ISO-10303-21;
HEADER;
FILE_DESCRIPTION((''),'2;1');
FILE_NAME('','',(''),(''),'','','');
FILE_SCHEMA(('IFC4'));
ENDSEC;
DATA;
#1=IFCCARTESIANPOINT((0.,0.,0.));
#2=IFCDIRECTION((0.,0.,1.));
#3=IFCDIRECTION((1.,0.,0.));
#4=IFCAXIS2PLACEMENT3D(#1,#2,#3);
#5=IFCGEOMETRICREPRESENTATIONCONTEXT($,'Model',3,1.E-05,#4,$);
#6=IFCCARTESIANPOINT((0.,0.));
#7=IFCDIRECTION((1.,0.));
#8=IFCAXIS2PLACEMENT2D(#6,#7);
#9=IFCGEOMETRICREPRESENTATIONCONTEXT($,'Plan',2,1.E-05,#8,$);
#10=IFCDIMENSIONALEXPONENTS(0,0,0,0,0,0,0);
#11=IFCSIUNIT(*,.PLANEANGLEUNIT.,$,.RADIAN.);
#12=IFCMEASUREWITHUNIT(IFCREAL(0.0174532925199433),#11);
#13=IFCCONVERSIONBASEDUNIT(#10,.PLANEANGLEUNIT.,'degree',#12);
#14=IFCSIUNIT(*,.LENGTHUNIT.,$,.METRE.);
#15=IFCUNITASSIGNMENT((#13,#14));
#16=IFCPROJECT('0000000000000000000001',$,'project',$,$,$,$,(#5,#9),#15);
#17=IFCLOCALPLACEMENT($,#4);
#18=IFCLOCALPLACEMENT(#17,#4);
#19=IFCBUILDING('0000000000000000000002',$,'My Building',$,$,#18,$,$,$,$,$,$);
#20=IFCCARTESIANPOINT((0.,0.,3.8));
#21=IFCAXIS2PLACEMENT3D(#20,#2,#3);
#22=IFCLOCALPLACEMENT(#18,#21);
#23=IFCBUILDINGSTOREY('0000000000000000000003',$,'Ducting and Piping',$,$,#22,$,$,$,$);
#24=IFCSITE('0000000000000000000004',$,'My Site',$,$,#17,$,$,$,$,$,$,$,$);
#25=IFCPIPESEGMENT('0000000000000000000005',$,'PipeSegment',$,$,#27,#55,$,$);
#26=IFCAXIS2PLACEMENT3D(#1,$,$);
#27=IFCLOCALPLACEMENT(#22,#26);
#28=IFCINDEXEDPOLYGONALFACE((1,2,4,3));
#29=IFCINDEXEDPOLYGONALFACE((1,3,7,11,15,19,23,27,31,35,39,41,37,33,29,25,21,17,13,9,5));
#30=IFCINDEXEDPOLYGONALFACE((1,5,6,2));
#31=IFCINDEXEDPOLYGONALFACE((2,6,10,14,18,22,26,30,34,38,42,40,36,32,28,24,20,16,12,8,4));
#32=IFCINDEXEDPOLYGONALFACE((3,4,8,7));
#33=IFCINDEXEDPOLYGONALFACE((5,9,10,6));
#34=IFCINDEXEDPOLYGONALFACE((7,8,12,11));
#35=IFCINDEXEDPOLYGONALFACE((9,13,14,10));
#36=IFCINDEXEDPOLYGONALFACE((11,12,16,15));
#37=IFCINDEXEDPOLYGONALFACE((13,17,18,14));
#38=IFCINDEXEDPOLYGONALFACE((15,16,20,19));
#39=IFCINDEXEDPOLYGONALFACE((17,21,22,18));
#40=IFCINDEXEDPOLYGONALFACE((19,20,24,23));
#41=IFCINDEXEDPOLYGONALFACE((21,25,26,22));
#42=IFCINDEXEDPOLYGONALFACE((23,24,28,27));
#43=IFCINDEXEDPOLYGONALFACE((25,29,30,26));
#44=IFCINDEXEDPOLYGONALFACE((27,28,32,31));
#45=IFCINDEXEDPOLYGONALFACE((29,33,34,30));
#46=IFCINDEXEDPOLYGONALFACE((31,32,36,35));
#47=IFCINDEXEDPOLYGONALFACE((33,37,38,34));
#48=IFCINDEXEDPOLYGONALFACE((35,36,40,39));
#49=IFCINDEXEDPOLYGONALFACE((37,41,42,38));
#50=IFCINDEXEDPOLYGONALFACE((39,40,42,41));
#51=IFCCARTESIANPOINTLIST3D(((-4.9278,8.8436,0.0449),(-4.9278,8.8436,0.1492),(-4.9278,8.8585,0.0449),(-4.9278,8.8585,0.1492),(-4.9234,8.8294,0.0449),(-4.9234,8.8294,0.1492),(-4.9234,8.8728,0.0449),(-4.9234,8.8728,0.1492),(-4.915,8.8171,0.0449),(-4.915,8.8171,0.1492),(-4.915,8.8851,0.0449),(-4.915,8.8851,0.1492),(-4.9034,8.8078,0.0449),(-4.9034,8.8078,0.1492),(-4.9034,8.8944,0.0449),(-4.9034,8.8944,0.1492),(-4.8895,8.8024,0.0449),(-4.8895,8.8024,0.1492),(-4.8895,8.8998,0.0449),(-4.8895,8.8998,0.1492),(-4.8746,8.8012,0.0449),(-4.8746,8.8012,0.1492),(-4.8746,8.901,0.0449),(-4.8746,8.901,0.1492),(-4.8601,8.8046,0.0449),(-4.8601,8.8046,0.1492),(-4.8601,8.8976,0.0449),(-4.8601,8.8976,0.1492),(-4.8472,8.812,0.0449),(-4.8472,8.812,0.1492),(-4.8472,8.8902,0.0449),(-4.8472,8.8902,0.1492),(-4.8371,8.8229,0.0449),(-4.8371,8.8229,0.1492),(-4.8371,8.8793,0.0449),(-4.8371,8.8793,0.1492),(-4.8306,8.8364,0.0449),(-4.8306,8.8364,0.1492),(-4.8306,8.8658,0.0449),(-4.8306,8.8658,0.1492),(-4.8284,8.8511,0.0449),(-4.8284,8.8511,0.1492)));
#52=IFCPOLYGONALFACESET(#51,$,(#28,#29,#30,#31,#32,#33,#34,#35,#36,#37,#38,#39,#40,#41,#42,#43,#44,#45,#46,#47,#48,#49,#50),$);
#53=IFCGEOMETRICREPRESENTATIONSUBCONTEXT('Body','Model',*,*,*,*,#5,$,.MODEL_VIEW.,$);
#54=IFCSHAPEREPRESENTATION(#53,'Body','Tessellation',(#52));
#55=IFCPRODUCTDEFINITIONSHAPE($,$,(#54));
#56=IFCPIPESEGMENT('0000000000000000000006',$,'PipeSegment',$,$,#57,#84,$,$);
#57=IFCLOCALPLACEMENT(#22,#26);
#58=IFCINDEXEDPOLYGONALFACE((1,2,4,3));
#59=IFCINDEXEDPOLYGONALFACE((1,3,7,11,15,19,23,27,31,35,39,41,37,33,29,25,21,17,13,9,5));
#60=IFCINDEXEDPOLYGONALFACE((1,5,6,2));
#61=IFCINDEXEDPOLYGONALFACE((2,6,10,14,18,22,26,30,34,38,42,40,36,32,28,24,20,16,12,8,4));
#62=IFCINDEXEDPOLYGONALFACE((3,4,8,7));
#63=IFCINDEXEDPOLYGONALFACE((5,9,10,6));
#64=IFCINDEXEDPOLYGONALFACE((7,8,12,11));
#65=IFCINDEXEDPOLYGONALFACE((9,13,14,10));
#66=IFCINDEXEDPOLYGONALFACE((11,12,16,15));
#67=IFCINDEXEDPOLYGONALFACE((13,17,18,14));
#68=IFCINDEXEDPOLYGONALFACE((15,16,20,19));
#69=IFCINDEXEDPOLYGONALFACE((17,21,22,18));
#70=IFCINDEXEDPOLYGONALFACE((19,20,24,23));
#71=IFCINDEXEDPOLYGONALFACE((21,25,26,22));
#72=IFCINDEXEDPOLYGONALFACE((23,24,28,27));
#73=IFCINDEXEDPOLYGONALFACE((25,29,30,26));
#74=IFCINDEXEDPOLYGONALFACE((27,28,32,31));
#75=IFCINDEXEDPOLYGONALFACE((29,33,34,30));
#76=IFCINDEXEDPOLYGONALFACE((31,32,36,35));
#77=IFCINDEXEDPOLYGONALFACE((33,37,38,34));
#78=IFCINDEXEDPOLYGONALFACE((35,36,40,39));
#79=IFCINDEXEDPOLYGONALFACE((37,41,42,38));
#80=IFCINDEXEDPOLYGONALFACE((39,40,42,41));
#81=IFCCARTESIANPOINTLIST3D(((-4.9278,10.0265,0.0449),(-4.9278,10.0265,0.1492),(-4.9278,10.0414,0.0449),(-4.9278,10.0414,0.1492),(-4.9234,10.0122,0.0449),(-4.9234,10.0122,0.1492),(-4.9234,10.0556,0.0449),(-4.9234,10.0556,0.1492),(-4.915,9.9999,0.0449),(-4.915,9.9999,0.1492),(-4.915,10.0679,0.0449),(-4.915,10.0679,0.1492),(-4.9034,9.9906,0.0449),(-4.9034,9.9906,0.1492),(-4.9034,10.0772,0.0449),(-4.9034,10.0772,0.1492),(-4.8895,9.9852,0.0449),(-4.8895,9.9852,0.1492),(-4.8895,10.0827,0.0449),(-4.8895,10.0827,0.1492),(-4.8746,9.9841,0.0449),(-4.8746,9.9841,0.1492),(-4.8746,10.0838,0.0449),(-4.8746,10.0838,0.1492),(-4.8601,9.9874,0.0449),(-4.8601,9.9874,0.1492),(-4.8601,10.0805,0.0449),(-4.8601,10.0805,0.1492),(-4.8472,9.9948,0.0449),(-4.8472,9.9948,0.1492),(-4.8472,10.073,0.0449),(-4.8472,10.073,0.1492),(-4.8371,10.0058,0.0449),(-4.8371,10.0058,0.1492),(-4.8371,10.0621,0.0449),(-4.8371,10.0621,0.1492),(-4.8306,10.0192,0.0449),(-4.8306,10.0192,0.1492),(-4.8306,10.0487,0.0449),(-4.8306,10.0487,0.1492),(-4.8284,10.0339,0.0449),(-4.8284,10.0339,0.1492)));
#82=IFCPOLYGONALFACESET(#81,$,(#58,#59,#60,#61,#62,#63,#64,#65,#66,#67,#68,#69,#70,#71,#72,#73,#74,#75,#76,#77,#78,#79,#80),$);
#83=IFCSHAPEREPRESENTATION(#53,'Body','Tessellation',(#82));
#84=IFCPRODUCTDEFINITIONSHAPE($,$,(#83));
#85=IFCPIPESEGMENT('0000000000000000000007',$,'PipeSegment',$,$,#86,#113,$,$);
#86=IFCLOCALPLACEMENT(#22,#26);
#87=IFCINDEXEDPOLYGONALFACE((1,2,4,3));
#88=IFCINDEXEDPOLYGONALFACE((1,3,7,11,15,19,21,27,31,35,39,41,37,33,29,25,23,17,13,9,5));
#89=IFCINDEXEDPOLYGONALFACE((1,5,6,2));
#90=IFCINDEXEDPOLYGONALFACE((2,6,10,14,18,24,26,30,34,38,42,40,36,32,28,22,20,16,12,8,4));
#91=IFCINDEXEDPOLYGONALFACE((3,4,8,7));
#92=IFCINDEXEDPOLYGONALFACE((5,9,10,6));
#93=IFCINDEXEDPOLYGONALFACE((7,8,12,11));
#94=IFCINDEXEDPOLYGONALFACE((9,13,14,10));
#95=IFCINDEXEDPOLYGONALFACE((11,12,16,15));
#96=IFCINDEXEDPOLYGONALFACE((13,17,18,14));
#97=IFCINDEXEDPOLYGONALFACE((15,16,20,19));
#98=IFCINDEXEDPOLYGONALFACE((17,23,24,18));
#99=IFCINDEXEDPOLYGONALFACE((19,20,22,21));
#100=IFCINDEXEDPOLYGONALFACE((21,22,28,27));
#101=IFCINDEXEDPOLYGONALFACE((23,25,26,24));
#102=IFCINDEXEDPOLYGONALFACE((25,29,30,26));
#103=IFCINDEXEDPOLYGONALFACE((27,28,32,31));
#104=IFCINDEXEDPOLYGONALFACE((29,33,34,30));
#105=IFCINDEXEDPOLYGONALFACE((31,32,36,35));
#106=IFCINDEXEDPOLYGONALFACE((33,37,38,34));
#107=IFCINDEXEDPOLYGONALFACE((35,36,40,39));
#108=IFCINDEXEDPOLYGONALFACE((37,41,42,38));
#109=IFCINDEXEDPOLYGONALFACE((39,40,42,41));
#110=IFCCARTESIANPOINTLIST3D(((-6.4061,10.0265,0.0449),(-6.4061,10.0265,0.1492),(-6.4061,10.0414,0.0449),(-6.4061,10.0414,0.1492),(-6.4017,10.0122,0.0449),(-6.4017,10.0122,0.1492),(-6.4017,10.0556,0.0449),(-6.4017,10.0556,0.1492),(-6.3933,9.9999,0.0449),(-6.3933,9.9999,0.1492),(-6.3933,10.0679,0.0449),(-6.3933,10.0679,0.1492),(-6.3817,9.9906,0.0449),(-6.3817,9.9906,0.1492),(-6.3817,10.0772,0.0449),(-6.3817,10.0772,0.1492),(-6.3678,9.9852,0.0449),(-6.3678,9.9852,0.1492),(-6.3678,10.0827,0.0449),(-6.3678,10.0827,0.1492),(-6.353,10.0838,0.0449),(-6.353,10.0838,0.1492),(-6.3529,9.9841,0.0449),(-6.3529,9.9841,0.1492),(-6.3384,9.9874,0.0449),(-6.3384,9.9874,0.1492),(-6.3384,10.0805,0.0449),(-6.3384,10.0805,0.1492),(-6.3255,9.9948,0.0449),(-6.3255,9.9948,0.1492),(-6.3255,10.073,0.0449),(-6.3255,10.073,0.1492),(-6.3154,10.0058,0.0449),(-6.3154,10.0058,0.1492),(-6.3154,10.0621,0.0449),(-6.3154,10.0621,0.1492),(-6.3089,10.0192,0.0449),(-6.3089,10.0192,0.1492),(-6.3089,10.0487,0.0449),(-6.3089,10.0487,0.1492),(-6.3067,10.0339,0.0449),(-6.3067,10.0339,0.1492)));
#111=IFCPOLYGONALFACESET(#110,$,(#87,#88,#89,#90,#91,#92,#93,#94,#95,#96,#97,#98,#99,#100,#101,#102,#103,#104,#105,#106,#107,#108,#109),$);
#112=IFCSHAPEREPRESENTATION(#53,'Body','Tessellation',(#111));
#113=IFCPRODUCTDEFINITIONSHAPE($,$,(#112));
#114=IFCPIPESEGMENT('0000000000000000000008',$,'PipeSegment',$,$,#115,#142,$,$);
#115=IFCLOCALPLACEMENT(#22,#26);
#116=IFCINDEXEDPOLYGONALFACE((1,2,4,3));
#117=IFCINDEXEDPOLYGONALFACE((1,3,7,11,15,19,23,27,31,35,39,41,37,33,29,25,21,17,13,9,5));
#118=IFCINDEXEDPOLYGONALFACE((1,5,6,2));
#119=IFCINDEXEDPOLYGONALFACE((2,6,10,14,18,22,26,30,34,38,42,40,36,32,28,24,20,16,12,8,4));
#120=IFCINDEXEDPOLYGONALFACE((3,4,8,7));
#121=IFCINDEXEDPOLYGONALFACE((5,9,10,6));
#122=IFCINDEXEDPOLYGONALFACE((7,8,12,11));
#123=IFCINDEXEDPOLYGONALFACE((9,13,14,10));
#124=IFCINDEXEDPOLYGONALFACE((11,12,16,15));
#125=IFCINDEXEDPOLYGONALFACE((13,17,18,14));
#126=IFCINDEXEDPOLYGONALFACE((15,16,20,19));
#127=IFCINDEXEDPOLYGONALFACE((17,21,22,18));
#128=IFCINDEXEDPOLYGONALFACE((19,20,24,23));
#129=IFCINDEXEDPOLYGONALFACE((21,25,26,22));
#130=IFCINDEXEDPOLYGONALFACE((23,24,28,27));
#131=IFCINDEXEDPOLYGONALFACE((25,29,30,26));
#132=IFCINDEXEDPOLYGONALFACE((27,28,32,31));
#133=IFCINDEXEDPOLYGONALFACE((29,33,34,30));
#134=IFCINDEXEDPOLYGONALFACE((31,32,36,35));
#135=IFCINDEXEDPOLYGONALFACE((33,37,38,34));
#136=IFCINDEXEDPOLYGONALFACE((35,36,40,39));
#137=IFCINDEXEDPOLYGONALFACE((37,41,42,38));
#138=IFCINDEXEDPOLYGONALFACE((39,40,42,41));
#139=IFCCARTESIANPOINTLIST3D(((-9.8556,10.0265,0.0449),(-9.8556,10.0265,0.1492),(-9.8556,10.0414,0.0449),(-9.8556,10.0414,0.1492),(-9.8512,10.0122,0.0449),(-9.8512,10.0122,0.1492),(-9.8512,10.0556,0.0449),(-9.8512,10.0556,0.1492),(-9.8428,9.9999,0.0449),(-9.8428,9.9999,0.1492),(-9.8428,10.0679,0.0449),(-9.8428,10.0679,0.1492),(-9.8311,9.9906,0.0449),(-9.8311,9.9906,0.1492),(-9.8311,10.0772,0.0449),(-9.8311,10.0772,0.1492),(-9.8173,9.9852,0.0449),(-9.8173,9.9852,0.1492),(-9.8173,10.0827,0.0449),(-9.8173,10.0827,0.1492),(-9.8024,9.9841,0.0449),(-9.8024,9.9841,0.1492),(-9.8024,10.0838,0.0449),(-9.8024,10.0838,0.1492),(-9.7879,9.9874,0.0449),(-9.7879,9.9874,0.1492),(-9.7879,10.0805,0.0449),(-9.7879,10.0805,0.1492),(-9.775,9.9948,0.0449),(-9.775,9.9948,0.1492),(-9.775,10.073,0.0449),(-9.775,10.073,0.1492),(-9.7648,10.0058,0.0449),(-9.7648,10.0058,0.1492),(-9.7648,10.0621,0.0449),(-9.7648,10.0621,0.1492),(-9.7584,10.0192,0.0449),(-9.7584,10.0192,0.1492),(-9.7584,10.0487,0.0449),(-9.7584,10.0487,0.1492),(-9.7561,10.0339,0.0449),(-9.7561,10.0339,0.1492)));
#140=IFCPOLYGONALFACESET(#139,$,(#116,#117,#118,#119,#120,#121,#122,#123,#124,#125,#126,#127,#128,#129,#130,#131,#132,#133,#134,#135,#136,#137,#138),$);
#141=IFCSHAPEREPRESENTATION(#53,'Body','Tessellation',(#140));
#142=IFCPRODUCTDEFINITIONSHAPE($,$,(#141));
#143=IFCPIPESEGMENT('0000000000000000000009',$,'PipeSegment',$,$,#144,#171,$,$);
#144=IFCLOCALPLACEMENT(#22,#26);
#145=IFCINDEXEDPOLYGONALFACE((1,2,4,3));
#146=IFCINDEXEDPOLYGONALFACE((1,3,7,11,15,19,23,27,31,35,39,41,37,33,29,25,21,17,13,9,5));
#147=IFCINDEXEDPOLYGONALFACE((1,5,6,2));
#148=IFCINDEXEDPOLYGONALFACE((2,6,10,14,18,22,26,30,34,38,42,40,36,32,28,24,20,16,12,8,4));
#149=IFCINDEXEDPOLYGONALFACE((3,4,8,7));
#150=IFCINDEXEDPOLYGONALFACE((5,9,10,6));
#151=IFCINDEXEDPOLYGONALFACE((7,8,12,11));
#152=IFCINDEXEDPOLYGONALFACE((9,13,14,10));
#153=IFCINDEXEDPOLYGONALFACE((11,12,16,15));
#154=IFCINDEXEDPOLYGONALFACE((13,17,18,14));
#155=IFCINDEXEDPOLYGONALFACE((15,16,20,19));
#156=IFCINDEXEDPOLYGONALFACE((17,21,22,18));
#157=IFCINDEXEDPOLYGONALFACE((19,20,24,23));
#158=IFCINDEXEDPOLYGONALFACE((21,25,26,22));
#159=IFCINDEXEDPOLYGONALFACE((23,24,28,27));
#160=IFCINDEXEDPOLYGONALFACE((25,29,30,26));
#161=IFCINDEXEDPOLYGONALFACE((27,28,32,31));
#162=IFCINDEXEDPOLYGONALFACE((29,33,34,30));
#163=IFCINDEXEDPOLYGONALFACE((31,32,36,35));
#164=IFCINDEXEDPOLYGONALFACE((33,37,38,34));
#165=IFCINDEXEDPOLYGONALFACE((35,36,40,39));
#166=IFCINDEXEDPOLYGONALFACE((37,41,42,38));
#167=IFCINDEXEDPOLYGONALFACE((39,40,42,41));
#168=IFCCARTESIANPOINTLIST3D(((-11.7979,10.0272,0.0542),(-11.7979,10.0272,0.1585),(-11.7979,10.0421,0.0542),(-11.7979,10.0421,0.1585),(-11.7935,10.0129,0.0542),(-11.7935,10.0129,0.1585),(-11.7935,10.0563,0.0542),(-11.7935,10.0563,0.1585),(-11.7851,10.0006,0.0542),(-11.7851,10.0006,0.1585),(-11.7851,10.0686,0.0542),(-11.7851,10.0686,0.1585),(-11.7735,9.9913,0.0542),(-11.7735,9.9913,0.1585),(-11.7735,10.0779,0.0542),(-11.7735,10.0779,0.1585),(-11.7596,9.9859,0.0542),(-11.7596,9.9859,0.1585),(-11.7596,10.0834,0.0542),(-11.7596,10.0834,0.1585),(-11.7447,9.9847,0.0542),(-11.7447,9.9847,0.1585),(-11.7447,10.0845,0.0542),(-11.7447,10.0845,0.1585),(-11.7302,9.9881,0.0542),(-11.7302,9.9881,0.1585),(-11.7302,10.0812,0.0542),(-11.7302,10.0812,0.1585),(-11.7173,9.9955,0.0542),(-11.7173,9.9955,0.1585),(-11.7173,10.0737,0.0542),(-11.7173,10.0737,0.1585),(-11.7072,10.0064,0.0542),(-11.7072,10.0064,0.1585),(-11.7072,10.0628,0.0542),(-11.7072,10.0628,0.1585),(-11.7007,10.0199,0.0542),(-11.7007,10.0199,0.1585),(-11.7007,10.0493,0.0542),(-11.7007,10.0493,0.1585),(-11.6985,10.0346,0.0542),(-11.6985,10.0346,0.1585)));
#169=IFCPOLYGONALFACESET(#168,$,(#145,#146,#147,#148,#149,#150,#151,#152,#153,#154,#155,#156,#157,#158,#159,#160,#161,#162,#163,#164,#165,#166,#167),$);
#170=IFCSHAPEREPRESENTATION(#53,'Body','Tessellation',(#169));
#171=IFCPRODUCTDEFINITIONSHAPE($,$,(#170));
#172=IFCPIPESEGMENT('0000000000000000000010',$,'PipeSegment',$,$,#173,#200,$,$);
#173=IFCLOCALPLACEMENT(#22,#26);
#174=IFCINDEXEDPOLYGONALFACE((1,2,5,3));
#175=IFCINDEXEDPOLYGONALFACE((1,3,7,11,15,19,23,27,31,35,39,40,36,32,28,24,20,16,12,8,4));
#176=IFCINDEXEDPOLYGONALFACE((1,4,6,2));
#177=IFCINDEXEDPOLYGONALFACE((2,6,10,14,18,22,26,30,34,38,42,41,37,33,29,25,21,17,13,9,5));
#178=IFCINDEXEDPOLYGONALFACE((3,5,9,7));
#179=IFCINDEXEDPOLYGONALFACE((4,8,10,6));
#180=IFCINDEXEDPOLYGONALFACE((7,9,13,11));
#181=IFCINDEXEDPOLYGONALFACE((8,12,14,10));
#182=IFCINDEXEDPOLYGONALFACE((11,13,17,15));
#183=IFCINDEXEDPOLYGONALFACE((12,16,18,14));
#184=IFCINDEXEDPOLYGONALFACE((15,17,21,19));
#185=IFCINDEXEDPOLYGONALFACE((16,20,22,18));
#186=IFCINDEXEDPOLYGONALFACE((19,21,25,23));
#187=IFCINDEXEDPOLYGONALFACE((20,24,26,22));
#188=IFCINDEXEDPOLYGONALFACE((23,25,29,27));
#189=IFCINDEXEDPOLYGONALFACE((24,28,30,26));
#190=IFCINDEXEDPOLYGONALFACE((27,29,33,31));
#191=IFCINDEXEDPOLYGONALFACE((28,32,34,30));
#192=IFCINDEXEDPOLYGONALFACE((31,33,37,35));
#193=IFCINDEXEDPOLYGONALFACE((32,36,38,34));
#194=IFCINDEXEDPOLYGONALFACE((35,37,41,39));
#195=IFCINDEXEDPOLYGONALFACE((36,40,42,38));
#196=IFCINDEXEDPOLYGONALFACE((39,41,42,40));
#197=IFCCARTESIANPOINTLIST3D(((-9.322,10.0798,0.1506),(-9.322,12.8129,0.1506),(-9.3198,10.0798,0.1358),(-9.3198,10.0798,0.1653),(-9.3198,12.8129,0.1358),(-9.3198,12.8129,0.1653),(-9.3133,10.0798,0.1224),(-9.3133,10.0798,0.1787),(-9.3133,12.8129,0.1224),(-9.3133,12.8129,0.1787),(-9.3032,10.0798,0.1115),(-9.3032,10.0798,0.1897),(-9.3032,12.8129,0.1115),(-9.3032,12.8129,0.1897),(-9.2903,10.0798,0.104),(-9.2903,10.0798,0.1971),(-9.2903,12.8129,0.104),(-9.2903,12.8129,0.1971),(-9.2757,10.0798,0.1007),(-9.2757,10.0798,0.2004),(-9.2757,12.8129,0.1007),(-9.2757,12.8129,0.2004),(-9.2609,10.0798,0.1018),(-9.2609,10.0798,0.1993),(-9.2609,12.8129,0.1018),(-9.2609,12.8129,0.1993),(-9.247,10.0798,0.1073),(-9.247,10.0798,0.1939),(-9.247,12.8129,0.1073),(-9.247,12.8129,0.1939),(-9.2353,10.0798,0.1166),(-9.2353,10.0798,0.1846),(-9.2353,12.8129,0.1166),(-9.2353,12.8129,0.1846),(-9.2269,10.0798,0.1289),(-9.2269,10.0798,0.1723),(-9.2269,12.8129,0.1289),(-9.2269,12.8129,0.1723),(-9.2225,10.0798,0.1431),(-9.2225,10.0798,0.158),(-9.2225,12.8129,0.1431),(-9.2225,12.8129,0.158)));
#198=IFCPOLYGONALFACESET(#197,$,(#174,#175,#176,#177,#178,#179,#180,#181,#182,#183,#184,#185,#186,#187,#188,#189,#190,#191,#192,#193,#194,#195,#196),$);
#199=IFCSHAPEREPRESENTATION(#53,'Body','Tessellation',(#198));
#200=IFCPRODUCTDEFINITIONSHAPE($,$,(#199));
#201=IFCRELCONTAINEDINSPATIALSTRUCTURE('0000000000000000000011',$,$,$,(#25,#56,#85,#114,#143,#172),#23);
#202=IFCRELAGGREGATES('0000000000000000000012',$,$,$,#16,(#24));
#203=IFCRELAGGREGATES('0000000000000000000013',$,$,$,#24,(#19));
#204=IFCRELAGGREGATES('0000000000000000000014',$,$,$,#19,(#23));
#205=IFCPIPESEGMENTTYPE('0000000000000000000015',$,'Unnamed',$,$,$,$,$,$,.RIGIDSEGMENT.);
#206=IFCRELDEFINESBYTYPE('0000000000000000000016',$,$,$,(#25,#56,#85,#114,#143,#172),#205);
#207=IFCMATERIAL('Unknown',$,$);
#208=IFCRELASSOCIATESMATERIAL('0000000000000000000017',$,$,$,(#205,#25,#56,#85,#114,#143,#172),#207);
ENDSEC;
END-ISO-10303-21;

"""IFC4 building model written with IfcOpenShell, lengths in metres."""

from ifc_helpers import new_model, entity, si_unit, converted_unit, frame, origin_with_axes, origin_2d_with_axis, place, context, subcontext, project, spatial, circle, extrude, material, material_profile, profile_set, profile_usage, type_object, element, save


model = new_model("IFC4")

# Units and contexts
model_context = context("Model", 3, precision=1e-05, world=origin_with_axes())
plan_context = context("Plan", 2, precision=1e-05, world=origin_2d_with_axis())
body_context = subcontext(model_context, "Body", "Model", "MODEL_VIEW")
ifc_project = project(units=[converted_unit("PLANEANGLEUNIT", "degree", entity("IfcReal", 0.0174532925199433), si_unit("PLANEANGLEUNIT", "RADIAN"), dimensions=[0, 0, 0, 0, 0, 0, 0]), si_unit("LENGTHUNIT", "METRE")], contexts=[model_context, plan_context])

# Site, building, storey
site_placement = place(None, origin_with_axes())
site = spatial("IfcSite", under=ifc_project, at=site_placement, Name="My Site")
building_placement = place(site_placement, origin_with_axes())
building = spatial("IfcBuilding", under=site, at=building_placement, Name="My Building")
storey_placement = place(building_placement, frame((0.0, 0.0, 3.8), z_axis=(0.0, 0.0, 1.0), x_axis=(1.0, 0.0, 0.0)))
storey = spatial("IfcBuildingStorey", under=building, at=storey_placement, Name="Ducting and Piping")

# Pipe segments
ifc_material = material(Name="Unknown")
ifc_material_profile_1 = material_profile(ifc_material, circle(Radius=0.05))
ifc_profile_set_1 = profile_set([ifc_material_profile_1])
pipe_segment_type = type_object("IfcPipeSegmentType", Name="Unnamed", PredefinedType="RIGIDSEGMENT", material=ifc_profile_set_1)
ifc_profile_usage_1 = profile_usage(ifc_profile_set_1, cardinal=5)
pipe_segment_1_placement = place(storey_placement, frame((-4.8784, 8.8511, 0.0449), z_axis=(0.0, 0.0, 1.0), x_axis=(1.0, 0.00006, 0.0)))
element("IfcPipeSegment", 1, at=pipe_segment_1_placement, inside=storey, type_object=pipe_segment_type, material=ifc_profile_usage_1, Name="PipeSegment", context=body_context, shape_type="SweptSolid", body=[
    extrude(circle(Radius=0.05), origin_with_axes(), (0.0, 0.0, 1.0), 0.1043),
])
ifc_profile_usage_2 = profile_usage(ifc_profile_set_1, cardinal=5)
pipe_segment_2_placement = place(storey_placement, frame((-4.8784, 10.0339, 0.0449), z_axis=(0.0, 0.0, 1.0), x_axis=(1.0, 0.00006, 0.0)))
element("IfcPipeSegment", 2, at=pipe_segment_2_placement, inside=storey, type_object=pipe_segment_type, material=ifc_profile_usage_2, Name="PipeSegment", context=body_context, shape_type="SweptSolid", body=[
    extrude(circle(Radius=0.05), origin_with_axes(), (0.0, 0.0, 1.0), 0.1043),
])
ifc_profile_usage_3 = profile_usage(ifc_profile_set_1, cardinal=5)
pipe_segment_3_placement = place(storey_placement, frame((-6.3567, 10.0339, 0.0449), z_axis=(0.0, 0.0, 1.0), x_axis=(1.0, 0.00006, 0.0)))
element("IfcPipeSegment", 3, at=pipe_segment_3_placement, inside=storey, type_object=pipe_segment_type, material=ifc_profile_usage_3, Name="PipeSegment", context=body_context, shape_type="SweptSolid", body=[
    extrude(circle(Radius=0.05), origin_with_axes(), (0.0, 0.0, 1.0), 0.1043),
])
ifc_profile_usage_4 = profile_usage(ifc_profile_set_1, cardinal=5)
pipe_segment_4_placement = place(storey_placement, frame((-9.8061, 10.0339, 0.0449), z_axis=(0.0, 0.0, 1.0), x_axis=(1.0, 0.00006, 0.0)))
element("IfcPipeSegment", 4, at=pipe_segment_4_placement, inside=storey, type_object=pipe_segment_type, material=ifc_profile_usage_4, Name="PipeSegment", context=body_context, shape_type="SweptSolid", body=[
    extrude(circle(Radius=0.05), origin_with_axes(), (0.0, 0.0, 1.0), 0.1043),
])
ifc_profile_usage_5 = profile_usage(ifc_profile_set_1, cardinal=5)
pipe_segment_5_placement = place(storey_placement, frame((-11.7485, 10.0346, 0.0542), z_axis=(0.0, 0.0, 1.0), x_axis=(1.0, 0.00006, 0.0)))
element("IfcPipeSegment", 5, at=pipe_segment_5_placement, inside=storey, type_object=pipe_segment_type, material=ifc_profile_usage_5, Name="PipeSegment", context=body_context, shape_type="SweptSolid", body=[
    extrude(circle(Radius=0.05), origin_with_axes(), (0.0, 0.0, 1.0), 0.1043),
])
ifc_profile_usage_6 = profile_usage(ifc_profile_set_1, cardinal=5)
pipe_segment_6_placement = place(storey_placement, frame((-9.272, 10.0798, 0.1506), z_axis=(0.0, 1.0, 0.0), x_axis=(-1.0, 0.0, 0.0)))
element("IfcPipeSegment", 6, at=pipe_segment_6_placement, inside=storey, type_object=pipe_segment_type, material=ifc_profile_usage_6, Name="PipeSegment", context=body_context, shape_type="SweptSolid", body=[
    extrude(circle(Radius=0.05), origin_with_axes(), (0.0, 0.0, 1.0), 2.7332),
])

save(model, "model.ifc")
